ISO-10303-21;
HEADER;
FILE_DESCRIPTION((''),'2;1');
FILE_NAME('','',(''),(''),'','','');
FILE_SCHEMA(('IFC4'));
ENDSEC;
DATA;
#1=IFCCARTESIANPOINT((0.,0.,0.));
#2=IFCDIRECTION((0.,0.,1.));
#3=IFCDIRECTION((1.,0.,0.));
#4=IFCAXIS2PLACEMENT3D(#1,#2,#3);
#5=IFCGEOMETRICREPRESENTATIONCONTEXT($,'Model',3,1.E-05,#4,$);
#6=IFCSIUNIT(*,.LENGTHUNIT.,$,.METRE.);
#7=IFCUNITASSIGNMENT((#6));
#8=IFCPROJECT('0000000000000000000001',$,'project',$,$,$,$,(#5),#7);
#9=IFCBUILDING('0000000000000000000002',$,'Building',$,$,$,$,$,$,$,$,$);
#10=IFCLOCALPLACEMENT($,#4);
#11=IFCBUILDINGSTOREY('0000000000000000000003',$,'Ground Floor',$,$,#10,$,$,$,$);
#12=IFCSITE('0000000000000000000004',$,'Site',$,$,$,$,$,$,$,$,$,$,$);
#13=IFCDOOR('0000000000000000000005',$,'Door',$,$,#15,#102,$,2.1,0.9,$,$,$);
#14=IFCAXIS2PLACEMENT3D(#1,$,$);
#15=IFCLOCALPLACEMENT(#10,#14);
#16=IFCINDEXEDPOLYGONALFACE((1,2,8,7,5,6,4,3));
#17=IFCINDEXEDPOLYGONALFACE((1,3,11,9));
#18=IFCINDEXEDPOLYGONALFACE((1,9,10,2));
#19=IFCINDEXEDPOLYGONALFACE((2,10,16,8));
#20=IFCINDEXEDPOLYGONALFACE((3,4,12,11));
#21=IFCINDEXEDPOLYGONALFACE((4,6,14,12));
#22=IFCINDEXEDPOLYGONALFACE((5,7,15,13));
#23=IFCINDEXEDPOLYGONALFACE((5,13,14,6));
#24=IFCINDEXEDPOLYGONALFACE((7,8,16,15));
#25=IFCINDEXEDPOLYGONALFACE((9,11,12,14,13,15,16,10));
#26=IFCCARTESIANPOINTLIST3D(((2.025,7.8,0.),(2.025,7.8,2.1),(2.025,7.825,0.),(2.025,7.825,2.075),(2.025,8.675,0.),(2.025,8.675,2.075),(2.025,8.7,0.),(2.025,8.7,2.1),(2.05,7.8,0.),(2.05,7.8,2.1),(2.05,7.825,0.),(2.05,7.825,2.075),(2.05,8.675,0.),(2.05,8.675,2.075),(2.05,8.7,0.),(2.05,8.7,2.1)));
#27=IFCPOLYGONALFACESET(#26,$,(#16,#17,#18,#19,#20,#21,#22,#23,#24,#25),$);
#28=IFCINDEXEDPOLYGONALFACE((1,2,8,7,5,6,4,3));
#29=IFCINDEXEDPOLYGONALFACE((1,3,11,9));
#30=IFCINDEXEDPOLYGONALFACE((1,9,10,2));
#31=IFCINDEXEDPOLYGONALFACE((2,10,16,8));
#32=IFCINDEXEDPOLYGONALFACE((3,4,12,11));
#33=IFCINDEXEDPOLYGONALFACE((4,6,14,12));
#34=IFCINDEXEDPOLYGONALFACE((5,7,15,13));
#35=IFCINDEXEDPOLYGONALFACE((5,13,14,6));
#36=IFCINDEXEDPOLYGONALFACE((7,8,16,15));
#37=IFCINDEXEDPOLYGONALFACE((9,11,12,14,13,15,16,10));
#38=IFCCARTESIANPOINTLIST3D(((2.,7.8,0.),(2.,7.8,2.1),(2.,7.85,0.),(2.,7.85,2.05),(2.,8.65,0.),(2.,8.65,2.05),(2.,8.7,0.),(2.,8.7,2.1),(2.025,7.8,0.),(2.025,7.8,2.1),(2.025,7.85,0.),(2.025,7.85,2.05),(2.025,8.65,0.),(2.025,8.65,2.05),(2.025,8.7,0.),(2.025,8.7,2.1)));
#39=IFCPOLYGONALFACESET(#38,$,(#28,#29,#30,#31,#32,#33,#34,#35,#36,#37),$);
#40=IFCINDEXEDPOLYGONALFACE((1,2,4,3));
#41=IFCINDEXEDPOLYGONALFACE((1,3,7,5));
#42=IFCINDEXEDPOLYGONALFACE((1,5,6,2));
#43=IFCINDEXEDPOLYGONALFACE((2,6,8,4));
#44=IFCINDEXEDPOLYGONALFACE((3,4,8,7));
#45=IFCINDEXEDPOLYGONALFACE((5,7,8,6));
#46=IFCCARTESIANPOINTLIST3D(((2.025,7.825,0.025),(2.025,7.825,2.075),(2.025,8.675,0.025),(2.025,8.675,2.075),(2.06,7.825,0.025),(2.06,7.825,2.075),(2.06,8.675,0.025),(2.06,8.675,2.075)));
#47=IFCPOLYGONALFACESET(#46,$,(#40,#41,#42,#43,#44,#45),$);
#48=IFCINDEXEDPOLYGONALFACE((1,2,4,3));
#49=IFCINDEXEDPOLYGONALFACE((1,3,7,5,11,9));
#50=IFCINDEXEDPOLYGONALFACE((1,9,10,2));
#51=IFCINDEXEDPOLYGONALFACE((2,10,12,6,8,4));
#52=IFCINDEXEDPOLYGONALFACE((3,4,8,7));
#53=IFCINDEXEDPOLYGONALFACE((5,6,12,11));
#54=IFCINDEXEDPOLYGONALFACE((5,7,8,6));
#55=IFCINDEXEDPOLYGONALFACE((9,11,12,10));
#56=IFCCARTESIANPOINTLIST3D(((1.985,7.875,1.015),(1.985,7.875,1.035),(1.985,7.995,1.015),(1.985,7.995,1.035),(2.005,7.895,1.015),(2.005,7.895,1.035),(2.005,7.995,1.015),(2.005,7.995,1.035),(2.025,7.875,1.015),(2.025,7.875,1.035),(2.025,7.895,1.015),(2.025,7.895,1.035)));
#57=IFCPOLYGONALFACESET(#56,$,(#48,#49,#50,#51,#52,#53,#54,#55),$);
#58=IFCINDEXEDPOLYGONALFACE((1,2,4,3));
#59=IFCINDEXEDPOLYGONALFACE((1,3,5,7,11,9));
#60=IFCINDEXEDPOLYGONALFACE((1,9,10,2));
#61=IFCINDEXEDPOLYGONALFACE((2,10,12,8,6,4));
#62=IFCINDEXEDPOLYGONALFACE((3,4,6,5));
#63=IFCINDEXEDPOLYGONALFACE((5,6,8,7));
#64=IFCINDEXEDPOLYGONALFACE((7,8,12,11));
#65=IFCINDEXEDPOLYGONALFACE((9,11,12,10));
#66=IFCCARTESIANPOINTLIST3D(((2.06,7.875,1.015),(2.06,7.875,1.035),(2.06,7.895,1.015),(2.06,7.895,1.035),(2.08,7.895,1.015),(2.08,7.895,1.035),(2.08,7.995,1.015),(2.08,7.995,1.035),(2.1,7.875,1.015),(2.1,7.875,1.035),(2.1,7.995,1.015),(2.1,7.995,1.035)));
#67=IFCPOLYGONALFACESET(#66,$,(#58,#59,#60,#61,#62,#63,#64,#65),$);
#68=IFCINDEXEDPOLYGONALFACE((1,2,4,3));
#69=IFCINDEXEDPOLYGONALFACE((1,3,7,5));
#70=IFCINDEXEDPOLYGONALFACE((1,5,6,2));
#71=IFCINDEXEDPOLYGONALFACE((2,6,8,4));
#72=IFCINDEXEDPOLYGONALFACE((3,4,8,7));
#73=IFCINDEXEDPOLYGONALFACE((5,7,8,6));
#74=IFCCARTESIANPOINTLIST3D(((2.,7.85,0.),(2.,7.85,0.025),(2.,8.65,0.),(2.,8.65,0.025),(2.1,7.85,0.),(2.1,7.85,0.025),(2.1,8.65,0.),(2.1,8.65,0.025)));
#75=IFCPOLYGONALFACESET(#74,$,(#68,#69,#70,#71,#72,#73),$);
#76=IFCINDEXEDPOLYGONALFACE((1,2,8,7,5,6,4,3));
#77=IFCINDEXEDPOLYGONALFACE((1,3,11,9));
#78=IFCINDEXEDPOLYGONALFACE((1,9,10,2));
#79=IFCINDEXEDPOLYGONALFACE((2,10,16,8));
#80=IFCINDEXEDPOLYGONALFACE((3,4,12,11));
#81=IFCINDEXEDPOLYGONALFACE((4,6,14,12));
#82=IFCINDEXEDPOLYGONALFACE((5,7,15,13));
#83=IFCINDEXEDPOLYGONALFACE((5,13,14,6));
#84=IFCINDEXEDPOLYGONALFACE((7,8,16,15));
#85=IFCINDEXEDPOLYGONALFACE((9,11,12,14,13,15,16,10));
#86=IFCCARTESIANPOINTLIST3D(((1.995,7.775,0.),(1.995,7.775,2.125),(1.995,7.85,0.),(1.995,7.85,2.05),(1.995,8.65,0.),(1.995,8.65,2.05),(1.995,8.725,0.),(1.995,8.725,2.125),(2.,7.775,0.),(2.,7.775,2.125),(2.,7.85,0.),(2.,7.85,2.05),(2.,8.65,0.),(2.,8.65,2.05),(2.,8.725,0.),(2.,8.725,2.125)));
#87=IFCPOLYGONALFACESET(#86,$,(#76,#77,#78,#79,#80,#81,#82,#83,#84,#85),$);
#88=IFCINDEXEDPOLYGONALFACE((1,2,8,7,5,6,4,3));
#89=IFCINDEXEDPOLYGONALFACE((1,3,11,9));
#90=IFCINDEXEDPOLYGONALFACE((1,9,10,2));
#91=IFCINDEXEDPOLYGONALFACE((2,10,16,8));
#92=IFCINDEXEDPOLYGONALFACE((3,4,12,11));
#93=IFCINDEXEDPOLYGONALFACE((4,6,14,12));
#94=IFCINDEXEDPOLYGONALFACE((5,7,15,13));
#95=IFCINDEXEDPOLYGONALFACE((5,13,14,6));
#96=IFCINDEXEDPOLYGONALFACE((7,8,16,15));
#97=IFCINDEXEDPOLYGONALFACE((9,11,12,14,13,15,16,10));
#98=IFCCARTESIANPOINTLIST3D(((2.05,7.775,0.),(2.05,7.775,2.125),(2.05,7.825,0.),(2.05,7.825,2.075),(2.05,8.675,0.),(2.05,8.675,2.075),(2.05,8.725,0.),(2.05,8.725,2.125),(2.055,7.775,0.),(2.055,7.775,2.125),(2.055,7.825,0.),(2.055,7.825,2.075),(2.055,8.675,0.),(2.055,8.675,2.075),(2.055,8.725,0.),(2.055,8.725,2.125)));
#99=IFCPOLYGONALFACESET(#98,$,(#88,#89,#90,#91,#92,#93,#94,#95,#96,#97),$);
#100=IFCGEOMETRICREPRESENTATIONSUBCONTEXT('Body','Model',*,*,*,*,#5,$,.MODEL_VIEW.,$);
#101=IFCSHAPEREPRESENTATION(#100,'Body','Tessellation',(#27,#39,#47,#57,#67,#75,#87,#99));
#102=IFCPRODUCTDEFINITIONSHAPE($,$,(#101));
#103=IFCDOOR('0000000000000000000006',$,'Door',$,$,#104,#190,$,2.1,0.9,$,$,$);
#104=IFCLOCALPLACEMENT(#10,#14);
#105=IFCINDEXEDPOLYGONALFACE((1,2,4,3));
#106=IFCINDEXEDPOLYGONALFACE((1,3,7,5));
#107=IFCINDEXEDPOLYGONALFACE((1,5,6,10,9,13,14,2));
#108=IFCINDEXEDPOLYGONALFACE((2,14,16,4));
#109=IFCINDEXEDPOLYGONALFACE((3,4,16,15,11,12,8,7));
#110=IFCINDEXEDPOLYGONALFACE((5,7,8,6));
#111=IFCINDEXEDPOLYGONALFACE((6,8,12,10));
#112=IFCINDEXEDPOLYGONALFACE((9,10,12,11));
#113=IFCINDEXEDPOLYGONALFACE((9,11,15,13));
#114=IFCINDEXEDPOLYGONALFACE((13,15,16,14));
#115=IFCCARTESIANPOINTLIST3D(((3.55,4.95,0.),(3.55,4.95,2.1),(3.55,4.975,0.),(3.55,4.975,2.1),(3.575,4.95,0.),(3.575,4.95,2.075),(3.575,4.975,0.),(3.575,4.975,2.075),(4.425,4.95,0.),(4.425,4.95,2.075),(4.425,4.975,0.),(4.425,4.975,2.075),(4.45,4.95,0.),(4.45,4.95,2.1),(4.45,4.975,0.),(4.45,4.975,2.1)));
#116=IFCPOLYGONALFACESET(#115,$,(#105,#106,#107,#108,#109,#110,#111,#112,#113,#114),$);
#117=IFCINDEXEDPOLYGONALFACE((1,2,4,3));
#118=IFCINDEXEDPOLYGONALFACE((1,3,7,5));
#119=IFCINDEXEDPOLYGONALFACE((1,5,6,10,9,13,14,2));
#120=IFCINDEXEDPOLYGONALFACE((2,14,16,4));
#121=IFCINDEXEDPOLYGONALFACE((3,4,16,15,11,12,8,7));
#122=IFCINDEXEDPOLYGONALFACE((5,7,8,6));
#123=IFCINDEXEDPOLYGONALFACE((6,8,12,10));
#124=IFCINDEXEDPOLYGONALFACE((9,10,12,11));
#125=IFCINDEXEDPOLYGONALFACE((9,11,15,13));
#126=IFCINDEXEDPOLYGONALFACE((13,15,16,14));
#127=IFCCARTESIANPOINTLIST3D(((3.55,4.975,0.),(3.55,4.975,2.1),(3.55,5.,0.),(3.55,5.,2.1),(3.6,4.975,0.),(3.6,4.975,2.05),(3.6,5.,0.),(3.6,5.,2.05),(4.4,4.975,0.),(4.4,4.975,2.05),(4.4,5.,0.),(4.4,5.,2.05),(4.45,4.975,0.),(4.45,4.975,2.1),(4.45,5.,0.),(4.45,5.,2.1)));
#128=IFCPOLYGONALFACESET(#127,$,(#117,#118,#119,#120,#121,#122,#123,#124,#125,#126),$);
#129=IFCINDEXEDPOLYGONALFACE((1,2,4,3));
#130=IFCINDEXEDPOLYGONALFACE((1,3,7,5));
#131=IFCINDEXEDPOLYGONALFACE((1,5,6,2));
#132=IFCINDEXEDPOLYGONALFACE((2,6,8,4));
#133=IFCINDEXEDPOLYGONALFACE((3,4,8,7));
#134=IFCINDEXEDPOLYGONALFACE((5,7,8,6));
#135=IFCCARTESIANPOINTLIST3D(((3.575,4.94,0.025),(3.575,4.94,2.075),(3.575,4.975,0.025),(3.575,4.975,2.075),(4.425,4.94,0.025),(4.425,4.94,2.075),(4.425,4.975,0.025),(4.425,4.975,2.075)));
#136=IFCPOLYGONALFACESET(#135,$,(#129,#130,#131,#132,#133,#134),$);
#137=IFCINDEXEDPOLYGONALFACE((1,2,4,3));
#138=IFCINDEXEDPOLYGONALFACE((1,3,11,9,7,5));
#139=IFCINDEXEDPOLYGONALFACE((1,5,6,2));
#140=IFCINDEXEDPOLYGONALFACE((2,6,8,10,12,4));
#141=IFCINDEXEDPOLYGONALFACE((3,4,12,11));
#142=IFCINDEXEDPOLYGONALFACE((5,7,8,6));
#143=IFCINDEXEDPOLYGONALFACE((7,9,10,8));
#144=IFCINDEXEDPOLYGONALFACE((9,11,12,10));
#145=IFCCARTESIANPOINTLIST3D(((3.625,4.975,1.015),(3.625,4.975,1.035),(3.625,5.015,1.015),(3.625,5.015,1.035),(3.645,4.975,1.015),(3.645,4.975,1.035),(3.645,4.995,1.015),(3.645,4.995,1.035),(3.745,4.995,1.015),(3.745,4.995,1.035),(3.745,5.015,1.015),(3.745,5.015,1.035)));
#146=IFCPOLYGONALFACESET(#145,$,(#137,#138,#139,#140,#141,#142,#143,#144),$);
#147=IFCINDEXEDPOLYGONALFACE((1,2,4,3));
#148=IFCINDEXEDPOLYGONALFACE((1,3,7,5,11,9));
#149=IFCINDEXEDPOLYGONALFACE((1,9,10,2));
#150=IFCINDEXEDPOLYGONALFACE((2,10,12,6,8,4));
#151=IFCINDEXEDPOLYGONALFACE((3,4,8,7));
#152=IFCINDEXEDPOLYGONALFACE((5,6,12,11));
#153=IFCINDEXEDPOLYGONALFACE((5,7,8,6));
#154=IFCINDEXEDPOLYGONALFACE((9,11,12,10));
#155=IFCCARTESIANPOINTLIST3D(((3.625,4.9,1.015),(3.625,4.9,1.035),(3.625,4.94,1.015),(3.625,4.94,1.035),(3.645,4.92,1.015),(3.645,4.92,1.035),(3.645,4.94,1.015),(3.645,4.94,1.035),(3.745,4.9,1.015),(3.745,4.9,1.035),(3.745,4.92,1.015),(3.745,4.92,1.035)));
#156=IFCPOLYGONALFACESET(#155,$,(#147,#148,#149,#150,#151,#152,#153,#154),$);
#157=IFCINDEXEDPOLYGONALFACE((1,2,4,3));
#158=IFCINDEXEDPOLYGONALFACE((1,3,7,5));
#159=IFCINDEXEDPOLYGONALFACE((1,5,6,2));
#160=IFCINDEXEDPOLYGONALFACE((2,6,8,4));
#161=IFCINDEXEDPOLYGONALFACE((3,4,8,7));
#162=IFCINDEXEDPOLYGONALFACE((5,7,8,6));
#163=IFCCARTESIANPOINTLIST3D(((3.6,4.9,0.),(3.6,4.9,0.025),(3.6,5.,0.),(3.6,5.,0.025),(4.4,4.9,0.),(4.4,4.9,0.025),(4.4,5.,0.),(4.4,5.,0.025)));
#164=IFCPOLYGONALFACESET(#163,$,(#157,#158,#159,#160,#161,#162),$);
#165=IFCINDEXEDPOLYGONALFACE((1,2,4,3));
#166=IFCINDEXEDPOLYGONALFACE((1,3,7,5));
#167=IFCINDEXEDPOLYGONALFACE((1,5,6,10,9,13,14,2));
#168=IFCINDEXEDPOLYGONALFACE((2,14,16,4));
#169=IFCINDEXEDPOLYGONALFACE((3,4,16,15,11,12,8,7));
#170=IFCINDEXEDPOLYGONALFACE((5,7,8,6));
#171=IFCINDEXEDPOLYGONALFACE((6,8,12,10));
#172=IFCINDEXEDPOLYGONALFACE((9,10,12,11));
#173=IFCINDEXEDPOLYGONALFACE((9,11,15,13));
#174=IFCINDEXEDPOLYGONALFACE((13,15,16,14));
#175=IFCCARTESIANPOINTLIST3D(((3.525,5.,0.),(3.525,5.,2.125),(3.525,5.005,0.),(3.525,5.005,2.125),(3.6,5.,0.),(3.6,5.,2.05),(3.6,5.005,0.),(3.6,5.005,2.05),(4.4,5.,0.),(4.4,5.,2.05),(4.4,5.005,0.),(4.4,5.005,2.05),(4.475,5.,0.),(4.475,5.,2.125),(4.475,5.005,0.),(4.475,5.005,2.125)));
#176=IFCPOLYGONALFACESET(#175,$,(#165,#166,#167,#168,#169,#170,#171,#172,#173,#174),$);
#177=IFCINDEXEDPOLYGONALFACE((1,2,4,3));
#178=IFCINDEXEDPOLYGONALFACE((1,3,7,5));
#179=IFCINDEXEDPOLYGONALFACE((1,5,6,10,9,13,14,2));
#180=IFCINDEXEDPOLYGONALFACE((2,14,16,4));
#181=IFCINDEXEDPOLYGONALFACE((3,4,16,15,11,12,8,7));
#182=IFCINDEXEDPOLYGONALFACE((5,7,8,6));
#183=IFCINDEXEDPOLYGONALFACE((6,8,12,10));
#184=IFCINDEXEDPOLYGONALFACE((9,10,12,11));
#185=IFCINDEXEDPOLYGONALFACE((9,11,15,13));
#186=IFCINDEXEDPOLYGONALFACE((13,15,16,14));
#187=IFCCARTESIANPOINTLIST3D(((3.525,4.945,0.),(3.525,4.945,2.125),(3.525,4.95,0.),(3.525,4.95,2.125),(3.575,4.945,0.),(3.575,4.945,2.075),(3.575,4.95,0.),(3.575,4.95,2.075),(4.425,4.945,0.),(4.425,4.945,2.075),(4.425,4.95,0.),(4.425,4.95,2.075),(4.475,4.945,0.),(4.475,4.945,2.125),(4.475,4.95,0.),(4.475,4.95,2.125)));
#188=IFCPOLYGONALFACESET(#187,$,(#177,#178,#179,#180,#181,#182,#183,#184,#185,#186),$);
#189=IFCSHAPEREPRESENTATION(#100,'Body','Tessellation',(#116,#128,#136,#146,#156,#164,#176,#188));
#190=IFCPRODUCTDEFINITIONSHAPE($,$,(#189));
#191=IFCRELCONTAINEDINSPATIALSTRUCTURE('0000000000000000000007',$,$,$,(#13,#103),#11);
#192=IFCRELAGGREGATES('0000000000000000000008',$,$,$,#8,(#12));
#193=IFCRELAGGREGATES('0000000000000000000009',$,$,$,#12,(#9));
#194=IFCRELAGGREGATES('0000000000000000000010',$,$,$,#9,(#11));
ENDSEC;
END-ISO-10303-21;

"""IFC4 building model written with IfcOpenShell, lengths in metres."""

from ifc_helpers import new_model, si_unit, frame, origin_with_axes, place, context, subcontext, project, spatial, line, indexed_curve, outline, extrude, element, save


model = new_model("IFC4")

# Units and contexts
model_context = context("Model", 3, precision=1e-05, world=origin_with_axes())
body_context = subcontext(model_context, "Body", "Model", "MODEL_VIEW")
ifc_project = project(units=[si_unit("LENGTHUNIT", "METRE")], contexts=[model_context])

# Site, building, storey
site = spatial("IfcSite", under=ifc_project, Name="Site")
building = spatial("IfcBuilding", under=site, Name="Building")
storey_placement = place(None, origin_with_axes())
storey = spatial("IfcBuildingStorey", under=building, at=storey_placement, Name="Ground Floor")

# Doors
door_1_placement = place(storey_placement, frame((2.0, 8.7, 0.0), z_axis=(0.0, 0.0, 1.0), x_axis=(0.0, -1.0, 0.0)))
element("IfcDoor", 1, at=door_1_placement, inside=storey, Name="Door", OverallHeight=2.1, OverallWidth=0.9, context=body_context, shape_type="SweptSolid", body=[
    extrude(outline(indexed_curve([(0.0, 0.0), (0.0, 2.1), (0.9, 2.1), (0.9, 0.0), (0.875, 0.0), (0.875, 2.075), (0.025, 2.075), (0.025, 0.0)], segments=[line(1, 2, 3, 4, 5, 6, 7, 8, 1)])), frame((0.0, 0.025, 0.0), z_axis=(0.0, -1.0, 0.0), x_axis=(1.0, 0.0, 0.0)), (0.0, 0.0, -1.0), 0.025),
    extrude(outline(indexed_curve([(0.0, 0.0), (0.0, 2.1), (0.9, 2.1), (0.9, 0.0), (0.85, 0.0), (0.85, 2.05), (0.05, 2.05), (0.05, 0.0)], segments=[line(1, 2, 3, 4, 5, 6, 7, 8, 1)])), frame((0.0, 0.0, 0.0), z_axis=(0.0, -1.0, 0.0), x_axis=(1.0, 0.0, 0.0)), (0.0, 0.0, -1.0), 0.025),
    extrude(outline(indexed_curve([(0.0, 0.0), (0.85, 0.0), (0.85, 0.035), (0.0, 0.035)], segments=[line(1, 2, 3, 4, 1)])), frame((0.025, 0.025, 0.025), z_axis=(0.0, 0.0, 1.0), x_axis=(1.0, 0.0, 0.0)), (0.0, 0.0, 1.0), 2.05),
    extrude(outline(indexed_curve([(0.0, 0.0), (0.0, -0.04), (-0.12, -0.04), (-0.12, -0.02), (-0.02, -0.02), (-0.02, 0.0)], segments=[line(1, 2, 3, 4, 5, 6, 1)])), frame((0.825, 0.025, 1.015), z_axis=(0.0, 0.0, 1.0), x_axis=(1.0, 0.0, 0.0)), (0.0, 0.0, 1.0), 0.02),
    extrude(outline(indexed_curve([(0.0, 0.0), (0.0, 0.04), (-0.12, 0.04), (-0.12, 0.02), (-0.02, 0.02), (-0.02, 0.0)], segments=[line(1, 2, 3, 4, 5, 6, 1)])), frame((0.825, 0.06, 1.015), z_axis=(0.0, 0.0, 1.0), x_axis=(1.0, 0.0, 0.0)), (0.0, 0.0, 1.0), 0.02),
    extrude(outline(indexed_curve([(0.0, 0.0), (0.8, 0.0), (0.8, 0.1), (0.0, 0.1)], segments=[line(1, 2, 3, 4, 1)])), frame((0.05, 0.0, 0.0), z_axis=(0.0, 0.0, 1.0), x_axis=(1.0, 0.0, 0.0)), (0.0, 0.0, 1.0), 0.025),
    extrude(outline(indexed_curve([(0.0, 0.0), (0.0, 2.125), (0.95, 2.125), (0.95, 0.0), (0.875, 0.0), (0.875, 2.05), (0.075, 2.05), (0.075, 0.0)], segments=[line(1, 2, 3, 4, 5, 6, 7, 8, 1)])), frame((-0.025, -0.005, 0.0), z_axis=(0.0, -1.0, 0.0), x_axis=(1.0, 0.0, 0.0)), (0.0, 0.0, -1.0), 0.005),
    extrude(outline(indexed_curve([(0.0, 0.0), (0.0, 2.125), (0.95, 2.125), (0.95, 0.0), (0.9, 0.0), (0.9, 2.075), (0.05, 2.075), (0.05, 0.0)], segments=[line(1, 2, 3, 4, 5, 6, 7, 8, 1)])), frame((-0.025, 0.05, 0.0), z_axis=(0.0, -1.0, 0.0), x_axis=(1.0, 0.0, 0.0)), (0.0, 0.0, -1.0), 0.005),
])
door_2_placement = place(storey_placement, frame((4.45, 5.0, 0.0), z_axis=(0.0, 0.0, 1.0), x_axis=(-1.0, 0.0, 0.0)))
element("IfcDoor", 2, at=door_2_placement, inside=storey, Name="Door", OverallHeight=2.1, OverallWidth=0.9, context=body_context, shape_type="SweptSolid", body=[
    extrude(outline(indexed_curve([(0.0, 0.0), (0.0, 2.1), (0.9, 2.1), (0.9, 0.0), (0.875, 0.0), (0.875, 2.075), (0.025, 2.075), (0.025, 0.0)], segments=[line(1, 2, 3, 4, 5, 6, 7, 8, 1)])), frame((0.0, 0.025, 0.0), z_axis=(0.0, -1.0, 0.0), x_axis=(1.0, 0.0, 0.0)), (0.0, 0.0, -1.0), 0.025),
    extrude(outline(indexed_curve([(0.0, 0.0), (0.0, 2.1), (0.9, 2.1), (0.9, 0.0), (0.85, 0.0), (0.85, 2.05), (0.05, 2.05), (0.05, 0.0)], segments=[line(1, 2, 3, 4, 5, 6, 7, 8, 1)])), frame((0.0, 0.0, 0.0), z_axis=(0.0, -1.0, 0.0), x_axis=(1.0, 0.0, 0.0)), (0.0, 0.0, -1.0), 0.025),
    extrude(outline(indexed_curve([(0.0, 0.0), (0.85, 0.0), (0.85, 0.035), (0.0, 0.035)], segments=[line(1, 2, 3, 4, 1)])), frame((0.025, 0.025, 0.025), z_axis=(0.0, 0.0, 1.0), x_axis=(1.0, 0.0, 0.0)), (0.0, 0.0, 1.0), 2.05),
    extrude(outline(indexed_curve([(0.0, 0.0), (0.0, -0.04), (-0.12, -0.04), (-0.12, -0.02), (-0.02, -0.02), (-0.02, 0.0)], segments=[line(1, 2, 3, 4, 5, 6, 1)])), frame((0.825, 0.025, 1.015), z_axis=(0.0, 0.0, 1.0), x_axis=(1.0, 0.0, 0.0)), (0.0, 0.0, 1.0), 0.02),
    extrude(outline(indexed_curve([(0.0, 0.0), (0.0, 0.04), (-0.12, 0.04), (-0.12, 0.02), (-0.02, 0.02), (-0.02, 0.0)], segments=[line(1, 2, 3, 4, 5, 6, 1)])), frame((0.825, 0.06, 1.015), z_axis=(0.0, 0.0, 1.0), x_axis=(1.0, 0.0, 0.0)), (0.0, 0.0, 1.0), 0.02),
    extrude(outline(indexed_curve([(0.0, 0.0), (0.8, 0.0), (0.8, 0.1), (0.0, 0.1)], segments=[line(1, 2, 3, 4, 1)])), frame((0.05, 0.0, 0.0), z_axis=(0.0, 0.0, 1.0), x_axis=(1.0, 0.0, 0.0)), (0.0, 0.0, 1.0), 0.025),
    extrude(outline(indexed_curve([(0.0, 0.0), (0.0, 2.125), (0.95, 2.125), (0.95, 0.0), (0.875, 0.0), (0.875, 2.05), (0.075, 2.05), (0.075, 0.0)], segments=[line(1, 2, 3, 4, 5, 6, 7, 8, 1)])), frame((-0.025, -0.005, 0.0), z_axis=(0.0, -1.0, 0.0), x_axis=(1.0, 0.0, 0.0)), (0.0, 0.0, -1.0), 0.005),
    extrude(outline(indexed_curve([(0.0, 0.0), (0.0, 2.125), (0.95, 2.125), (0.95, 0.0), (0.9, 0.0), (0.9, 2.075), (0.05, 2.075), (0.05, 0.0)], segments=[line(1, 2, 3, 4, 5, 6, 7, 8, 1)])), frame((-0.025, 0.05, 0.0), z_axis=(0.0, -1.0, 0.0), x_axis=(1.0, 0.0, 0.0)), (0.0, 0.0, -1.0), 0.005),
])

save(model, "model.ifc")
